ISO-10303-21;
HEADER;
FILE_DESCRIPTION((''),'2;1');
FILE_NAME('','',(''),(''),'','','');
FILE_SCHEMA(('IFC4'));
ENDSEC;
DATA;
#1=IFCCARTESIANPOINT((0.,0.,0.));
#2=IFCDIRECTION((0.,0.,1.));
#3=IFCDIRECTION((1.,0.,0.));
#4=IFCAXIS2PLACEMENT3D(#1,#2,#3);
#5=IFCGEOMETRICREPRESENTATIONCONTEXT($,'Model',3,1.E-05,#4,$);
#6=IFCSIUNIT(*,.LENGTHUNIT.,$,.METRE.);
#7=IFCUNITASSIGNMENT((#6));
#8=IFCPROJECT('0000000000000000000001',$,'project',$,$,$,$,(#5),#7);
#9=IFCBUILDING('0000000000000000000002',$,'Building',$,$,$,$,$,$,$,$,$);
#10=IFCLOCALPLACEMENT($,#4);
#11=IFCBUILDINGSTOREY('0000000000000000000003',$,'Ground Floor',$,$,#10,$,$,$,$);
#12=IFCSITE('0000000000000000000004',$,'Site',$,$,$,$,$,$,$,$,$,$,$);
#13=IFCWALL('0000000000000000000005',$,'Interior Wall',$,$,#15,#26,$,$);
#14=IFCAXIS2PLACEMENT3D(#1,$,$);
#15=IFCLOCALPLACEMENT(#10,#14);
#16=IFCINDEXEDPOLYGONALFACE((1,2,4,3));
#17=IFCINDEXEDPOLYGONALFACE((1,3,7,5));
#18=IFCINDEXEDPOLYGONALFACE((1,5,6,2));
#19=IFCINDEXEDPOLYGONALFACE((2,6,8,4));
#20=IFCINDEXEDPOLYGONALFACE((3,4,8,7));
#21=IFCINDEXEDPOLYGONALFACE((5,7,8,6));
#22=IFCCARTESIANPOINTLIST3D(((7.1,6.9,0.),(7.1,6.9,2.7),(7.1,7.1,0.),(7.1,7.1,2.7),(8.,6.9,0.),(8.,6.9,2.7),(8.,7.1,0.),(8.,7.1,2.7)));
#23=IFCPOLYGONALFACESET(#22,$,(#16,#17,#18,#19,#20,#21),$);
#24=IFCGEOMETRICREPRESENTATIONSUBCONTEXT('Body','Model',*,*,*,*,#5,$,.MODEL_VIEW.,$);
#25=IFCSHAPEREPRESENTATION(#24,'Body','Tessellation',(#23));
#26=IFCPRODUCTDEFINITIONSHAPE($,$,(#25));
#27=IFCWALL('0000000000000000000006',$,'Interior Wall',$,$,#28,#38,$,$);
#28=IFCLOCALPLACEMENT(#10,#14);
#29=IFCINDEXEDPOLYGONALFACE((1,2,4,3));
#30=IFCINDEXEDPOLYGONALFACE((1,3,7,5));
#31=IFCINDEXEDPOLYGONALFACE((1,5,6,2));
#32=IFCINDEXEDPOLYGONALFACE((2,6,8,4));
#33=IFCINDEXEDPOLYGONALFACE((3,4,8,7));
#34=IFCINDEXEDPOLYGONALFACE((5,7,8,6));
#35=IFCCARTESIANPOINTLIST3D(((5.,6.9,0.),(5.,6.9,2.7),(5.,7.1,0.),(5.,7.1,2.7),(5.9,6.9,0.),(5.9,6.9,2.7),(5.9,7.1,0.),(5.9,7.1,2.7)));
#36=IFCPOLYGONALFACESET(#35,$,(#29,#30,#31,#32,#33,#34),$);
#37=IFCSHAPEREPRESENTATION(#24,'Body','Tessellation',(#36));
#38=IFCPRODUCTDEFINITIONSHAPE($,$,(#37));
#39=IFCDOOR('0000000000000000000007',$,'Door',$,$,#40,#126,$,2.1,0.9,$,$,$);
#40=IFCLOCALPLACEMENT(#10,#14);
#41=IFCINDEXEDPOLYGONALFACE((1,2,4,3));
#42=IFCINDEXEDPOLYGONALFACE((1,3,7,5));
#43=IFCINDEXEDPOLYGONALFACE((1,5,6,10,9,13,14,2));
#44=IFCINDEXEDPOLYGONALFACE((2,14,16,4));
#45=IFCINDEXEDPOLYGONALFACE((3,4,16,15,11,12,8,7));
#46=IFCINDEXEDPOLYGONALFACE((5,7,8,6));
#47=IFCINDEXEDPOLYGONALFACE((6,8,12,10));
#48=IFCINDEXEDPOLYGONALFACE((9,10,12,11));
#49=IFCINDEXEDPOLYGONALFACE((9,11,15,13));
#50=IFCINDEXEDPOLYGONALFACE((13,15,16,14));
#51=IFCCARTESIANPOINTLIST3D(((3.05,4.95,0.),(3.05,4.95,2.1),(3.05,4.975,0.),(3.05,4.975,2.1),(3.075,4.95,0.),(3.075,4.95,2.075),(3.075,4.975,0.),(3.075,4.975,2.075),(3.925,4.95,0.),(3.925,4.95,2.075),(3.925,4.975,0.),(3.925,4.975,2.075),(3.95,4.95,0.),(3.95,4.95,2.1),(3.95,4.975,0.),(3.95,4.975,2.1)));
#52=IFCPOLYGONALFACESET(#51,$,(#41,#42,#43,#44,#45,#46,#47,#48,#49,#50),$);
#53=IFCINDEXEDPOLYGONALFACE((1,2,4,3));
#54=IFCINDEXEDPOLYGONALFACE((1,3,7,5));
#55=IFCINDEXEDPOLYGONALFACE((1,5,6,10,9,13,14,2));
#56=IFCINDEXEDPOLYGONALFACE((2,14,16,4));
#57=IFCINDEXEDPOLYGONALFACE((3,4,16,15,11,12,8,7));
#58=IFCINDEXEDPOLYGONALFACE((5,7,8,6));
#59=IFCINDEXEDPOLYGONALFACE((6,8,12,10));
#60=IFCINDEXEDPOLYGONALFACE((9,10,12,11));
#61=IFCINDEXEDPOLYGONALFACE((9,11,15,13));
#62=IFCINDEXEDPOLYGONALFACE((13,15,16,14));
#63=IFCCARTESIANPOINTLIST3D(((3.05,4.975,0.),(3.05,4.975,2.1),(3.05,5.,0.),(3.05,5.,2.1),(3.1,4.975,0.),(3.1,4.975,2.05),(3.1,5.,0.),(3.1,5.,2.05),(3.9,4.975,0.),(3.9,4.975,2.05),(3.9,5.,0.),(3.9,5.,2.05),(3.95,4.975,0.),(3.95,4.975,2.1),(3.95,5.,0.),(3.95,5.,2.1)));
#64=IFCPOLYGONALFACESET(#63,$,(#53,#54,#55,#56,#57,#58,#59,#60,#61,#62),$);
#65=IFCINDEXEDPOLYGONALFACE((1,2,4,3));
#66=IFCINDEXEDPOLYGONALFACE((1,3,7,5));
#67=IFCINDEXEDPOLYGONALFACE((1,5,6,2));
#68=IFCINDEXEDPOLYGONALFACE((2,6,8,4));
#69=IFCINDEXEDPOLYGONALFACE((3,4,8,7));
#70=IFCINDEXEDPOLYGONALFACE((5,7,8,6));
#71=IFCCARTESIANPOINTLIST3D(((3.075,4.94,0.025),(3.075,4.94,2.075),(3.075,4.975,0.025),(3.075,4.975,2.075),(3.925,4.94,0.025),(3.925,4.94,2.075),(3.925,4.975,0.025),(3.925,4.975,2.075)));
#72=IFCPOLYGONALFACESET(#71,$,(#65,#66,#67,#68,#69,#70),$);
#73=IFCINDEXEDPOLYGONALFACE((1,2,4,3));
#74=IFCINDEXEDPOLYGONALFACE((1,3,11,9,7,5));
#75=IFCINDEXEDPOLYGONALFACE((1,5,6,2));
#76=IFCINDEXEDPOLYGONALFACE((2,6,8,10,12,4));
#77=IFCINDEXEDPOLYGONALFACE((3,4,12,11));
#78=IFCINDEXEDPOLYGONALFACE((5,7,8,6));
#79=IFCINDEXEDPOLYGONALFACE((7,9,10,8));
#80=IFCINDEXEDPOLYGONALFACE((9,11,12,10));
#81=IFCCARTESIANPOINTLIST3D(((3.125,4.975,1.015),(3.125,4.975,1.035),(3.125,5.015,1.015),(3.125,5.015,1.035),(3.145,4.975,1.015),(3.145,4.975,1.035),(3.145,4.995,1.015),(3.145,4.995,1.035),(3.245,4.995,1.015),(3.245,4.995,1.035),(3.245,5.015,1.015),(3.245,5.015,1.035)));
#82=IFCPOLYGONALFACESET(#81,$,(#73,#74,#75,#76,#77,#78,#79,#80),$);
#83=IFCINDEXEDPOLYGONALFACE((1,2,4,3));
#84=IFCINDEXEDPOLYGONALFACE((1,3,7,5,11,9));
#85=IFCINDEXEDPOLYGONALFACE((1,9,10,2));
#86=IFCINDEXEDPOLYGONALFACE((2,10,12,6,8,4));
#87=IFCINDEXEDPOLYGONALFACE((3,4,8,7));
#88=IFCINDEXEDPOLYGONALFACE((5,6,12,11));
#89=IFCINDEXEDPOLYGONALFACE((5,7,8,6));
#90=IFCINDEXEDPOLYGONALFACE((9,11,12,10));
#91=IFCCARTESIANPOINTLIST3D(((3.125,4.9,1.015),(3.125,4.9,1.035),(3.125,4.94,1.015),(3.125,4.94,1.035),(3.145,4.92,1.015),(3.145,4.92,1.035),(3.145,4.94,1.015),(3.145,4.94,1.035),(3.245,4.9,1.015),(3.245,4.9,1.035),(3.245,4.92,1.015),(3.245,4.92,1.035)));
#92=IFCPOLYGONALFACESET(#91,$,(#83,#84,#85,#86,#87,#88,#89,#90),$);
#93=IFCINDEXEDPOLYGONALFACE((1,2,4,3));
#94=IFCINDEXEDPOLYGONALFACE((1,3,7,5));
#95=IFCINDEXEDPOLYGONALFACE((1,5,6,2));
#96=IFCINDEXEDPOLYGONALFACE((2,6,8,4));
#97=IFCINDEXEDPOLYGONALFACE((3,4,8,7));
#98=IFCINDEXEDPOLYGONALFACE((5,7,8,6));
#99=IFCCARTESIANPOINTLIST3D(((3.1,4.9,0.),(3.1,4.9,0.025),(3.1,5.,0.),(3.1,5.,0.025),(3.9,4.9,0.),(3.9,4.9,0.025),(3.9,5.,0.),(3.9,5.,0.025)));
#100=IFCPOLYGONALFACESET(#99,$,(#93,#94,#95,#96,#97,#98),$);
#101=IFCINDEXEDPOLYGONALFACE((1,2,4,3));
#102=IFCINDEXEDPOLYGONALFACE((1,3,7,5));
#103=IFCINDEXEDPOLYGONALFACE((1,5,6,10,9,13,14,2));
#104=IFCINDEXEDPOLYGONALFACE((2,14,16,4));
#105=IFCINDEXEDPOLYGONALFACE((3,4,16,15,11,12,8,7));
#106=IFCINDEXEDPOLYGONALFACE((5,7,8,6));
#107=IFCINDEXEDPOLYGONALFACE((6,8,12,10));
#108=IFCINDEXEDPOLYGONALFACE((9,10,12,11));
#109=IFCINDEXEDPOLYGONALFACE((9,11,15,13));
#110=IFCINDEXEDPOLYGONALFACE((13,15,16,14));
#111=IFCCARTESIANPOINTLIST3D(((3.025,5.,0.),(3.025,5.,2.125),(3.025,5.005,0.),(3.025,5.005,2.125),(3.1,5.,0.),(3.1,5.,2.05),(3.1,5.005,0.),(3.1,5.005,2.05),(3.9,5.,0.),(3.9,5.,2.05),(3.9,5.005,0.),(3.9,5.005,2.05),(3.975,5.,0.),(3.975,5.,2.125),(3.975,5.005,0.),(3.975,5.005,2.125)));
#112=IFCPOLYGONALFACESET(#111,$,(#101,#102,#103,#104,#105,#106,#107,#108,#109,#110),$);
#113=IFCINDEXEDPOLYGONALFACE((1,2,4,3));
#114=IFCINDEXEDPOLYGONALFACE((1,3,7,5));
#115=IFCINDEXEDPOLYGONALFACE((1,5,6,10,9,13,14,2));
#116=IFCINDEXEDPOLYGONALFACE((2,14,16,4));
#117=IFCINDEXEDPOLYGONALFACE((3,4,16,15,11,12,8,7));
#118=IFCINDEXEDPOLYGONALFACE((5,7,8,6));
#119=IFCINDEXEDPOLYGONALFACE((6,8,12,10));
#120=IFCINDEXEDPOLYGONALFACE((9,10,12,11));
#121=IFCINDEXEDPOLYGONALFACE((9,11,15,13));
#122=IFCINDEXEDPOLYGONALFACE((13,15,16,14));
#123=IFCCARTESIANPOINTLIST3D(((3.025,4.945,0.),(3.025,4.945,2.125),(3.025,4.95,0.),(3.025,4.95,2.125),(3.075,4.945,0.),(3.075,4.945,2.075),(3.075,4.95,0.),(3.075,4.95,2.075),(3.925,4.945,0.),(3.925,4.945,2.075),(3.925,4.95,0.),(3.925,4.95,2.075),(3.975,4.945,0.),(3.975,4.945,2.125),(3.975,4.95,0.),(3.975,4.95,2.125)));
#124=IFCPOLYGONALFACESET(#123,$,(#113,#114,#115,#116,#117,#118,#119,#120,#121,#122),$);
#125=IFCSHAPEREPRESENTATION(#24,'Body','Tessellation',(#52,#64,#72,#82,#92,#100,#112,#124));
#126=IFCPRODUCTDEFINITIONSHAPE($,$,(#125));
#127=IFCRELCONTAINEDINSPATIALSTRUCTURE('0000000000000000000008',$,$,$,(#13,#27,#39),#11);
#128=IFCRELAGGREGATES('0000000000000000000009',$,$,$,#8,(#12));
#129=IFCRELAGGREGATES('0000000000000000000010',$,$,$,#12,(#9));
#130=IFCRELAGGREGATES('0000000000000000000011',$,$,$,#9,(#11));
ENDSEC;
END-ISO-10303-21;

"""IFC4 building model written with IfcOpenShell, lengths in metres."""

from ifc_helpers import new_model, si_unit, frame, origin_with_axes, place, context, subcontext, project, spatial, line, indexed_curve, outline, extrude, element, save


model = new_model("IFC4")

# Units and contexts
model_context = context("Model", 3, precision=1e-05, world=origin_with_axes())
body_context = subcontext(model_context, "Body", "Model", "MODEL_VIEW")
ifc_project = project(units=[si_unit("LENGTHUNIT", "METRE")], contexts=[model_context])

# Site, building, storey
site = spatial("IfcSite", under=ifc_project, Name="Site")
building = spatial("IfcBuilding", under=site, Name="Building")
storey_placement = place(None, origin_with_axes())
storey = spatial("IfcBuildingStorey", under=building, at=storey_placement, Name="Ground Floor")

# Walls
for number, where, z_axis, x_axis, name in (
    (1, (8.0, 7.0, 0.0), (0.0, 0.0, 1.0), (-1.0, 0.0, 0.0), "Interior Wall"),
    (2, (5.9, 7.0, 0.0), (0.0, 0.0, 1.0), (-1.0, 0.0, 0.0), "Interior Wall"),
):
    element("IfcWall", number, at=place(storey_placement, frame(where, z_axis=z_axis, x_axis=x_axis)), inside=storey, Name=name, context=body_context, shape_type="SweptSolid", body=[
        extrude(outline(indexed_curve([(0.0, 0.0), (0.0, 0.2), (0.9, 0.2), (0.9, 0.0), (0.0, 0.0)], self_intersect=False)), frame((0.0, -0.1, 0.0), z_axis=(0.0, 0.0, 1.0), x_axis=(1.0, 0.0, 0.0)), (0.0, 0.0, 1.0), 2.7),
    ])

# Door
door_1_placement = place(storey_placement, frame((3.95, 5.0, 0.0), z_axis=(0.0, 0.0, 1.0), x_axis=(-1.0, 0.0, 0.0)))
element("IfcDoor", 3, at=door_1_placement, inside=storey, Name="Door", OverallHeight=2.1, OverallWidth=0.9, context=body_context, shape_type="SweptSolid", body=[
    extrude(outline(indexed_curve([(0.0, 0.0), (0.0, 2.1), (0.9, 2.1), (0.9, 0.0), (0.875, 0.0), (0.875, 2.075), (0.025, 2.075), (0.025, 0.0)], segments=[line(1, 2, 3, 4, 5, 6, 7, 8, 1)])), frame((0.0, 0.025, 0.0), z_axis=(0.0, -1.0, 0.0), x_axis=(1.0, 0.0, 0.0)), (0.0, 0.0, -1.0), 0.025),
    extrude(outline(indexed_curve([(0.0, 0.0), (0.0, 2.1), (0.9, 2.1), (0.9, 0.0), (0.85, 0.0), (0.85, 2.05), (0.05, 2.05), (0.05, 0.0)], segments=[line(1, 2, 3, 4, 5, 6, 7, 8, 1)])), frame((0.0, 0.0, 0.0), z_axis=(0.0, -1.0, 0.0), x_axis=(1.0, 0.0, 0.0)), (0.0, 0.0, -1.0), 0.025),
    extrude(outline(indexed_curve([(0.0, 0.0), (0.85, 0.0), (0.85, 0.035), (0.0, 0.035)], segments=[line(1, 2, 3, 4, 1)])), frame((0.025, 0.025, 0.025), z_axis=(0.0, 0.0, 1.0), x_axis=(1.0, 0.0, 0.0)), (0.0, 0.0, 1.0), 2.05),
    extrude(outline(indexed_curve([(0.0, 0.0), (0.0, -0.04), (-0.12, -0.04), (-0.12, -0.02), (-0.02, -0.02), (-0.02, 0.0)], segments=[line(1, 2, 3, 4, 5, 6, 1)])), frame((0.825, 0.025, 1.015), z_axis=(0.0, 0.0, 1.0), x_axis=(1.0, 0.0, 0.0)), (0.0, 0.0, 1.0), 0.02),
    extrude(outline(indexed_curve([(0.0, 0.0), (0.0, 0.04), (-0.12, 0.04), (-0.12, 0.02), (-0.02, 0.02), (-0.02, 0.0)], segments=[line(1, 2, 3, 4, 5, 6, 1)])), frame((0.825, 0.06, 1.015), z_axis=(0.0, 0.0, 1.0), x_axis=(1.0, 0.0, 0.0)), (0.0, 0.0, 1.0), 0.02),
    extrude(outline(indexed_curve([(0.0, 0.0), (0.8, 0.0), (0.8, 0.1), (0.0, 0.1)], segments=[line(1, 2, 3, 4, 1)])), frame((0.05, 0.0, 0.0), z_axis=(0.0, 0.0, 1.0), x_axis=(1.0, 0.0, 0.0)), (0.0, 0.0, 1.0), 0.025),
    extrude(outline(indexed_curve([(0.0, 0.0), (0.0, 2.125), (0.95, 2.125), (0.95, 0.0), (0.875, 0.0), (0.875, 2.05), (0.075, 2.05), (0.075, 0.0)], segments=[line(1, 2, 3, 4, 5, 6, 7, 8, 1)])), frame((-0.025, -0.005, 0.0), z_axis=(0.0, -1.0, 0.0), x_axis=(1.0, 0.0, 0.0)), (0.0, 0.0, -1.0), 0.005),
    extrude(outline(indexed_curve([(0.0, 0.0), (0.0, 2.125), (0.95, 2.125), (0.95, 0.0), (0.9, 0.0), (0.9, 2.075), (0.05, 2.075), (0.05, 0.0)], segments=[line(1, 2, 3, 4, 5, 6, 7, 8, 1)])), frame((-0.025, 0.05, 0.0), z_axis=(0.0, -1.0, 0.0), x_axis=(1.0, 0.0, 0.0)), (0.0, 0.0, -1.0), 0.005),
])

save(model, "model.ifc")
